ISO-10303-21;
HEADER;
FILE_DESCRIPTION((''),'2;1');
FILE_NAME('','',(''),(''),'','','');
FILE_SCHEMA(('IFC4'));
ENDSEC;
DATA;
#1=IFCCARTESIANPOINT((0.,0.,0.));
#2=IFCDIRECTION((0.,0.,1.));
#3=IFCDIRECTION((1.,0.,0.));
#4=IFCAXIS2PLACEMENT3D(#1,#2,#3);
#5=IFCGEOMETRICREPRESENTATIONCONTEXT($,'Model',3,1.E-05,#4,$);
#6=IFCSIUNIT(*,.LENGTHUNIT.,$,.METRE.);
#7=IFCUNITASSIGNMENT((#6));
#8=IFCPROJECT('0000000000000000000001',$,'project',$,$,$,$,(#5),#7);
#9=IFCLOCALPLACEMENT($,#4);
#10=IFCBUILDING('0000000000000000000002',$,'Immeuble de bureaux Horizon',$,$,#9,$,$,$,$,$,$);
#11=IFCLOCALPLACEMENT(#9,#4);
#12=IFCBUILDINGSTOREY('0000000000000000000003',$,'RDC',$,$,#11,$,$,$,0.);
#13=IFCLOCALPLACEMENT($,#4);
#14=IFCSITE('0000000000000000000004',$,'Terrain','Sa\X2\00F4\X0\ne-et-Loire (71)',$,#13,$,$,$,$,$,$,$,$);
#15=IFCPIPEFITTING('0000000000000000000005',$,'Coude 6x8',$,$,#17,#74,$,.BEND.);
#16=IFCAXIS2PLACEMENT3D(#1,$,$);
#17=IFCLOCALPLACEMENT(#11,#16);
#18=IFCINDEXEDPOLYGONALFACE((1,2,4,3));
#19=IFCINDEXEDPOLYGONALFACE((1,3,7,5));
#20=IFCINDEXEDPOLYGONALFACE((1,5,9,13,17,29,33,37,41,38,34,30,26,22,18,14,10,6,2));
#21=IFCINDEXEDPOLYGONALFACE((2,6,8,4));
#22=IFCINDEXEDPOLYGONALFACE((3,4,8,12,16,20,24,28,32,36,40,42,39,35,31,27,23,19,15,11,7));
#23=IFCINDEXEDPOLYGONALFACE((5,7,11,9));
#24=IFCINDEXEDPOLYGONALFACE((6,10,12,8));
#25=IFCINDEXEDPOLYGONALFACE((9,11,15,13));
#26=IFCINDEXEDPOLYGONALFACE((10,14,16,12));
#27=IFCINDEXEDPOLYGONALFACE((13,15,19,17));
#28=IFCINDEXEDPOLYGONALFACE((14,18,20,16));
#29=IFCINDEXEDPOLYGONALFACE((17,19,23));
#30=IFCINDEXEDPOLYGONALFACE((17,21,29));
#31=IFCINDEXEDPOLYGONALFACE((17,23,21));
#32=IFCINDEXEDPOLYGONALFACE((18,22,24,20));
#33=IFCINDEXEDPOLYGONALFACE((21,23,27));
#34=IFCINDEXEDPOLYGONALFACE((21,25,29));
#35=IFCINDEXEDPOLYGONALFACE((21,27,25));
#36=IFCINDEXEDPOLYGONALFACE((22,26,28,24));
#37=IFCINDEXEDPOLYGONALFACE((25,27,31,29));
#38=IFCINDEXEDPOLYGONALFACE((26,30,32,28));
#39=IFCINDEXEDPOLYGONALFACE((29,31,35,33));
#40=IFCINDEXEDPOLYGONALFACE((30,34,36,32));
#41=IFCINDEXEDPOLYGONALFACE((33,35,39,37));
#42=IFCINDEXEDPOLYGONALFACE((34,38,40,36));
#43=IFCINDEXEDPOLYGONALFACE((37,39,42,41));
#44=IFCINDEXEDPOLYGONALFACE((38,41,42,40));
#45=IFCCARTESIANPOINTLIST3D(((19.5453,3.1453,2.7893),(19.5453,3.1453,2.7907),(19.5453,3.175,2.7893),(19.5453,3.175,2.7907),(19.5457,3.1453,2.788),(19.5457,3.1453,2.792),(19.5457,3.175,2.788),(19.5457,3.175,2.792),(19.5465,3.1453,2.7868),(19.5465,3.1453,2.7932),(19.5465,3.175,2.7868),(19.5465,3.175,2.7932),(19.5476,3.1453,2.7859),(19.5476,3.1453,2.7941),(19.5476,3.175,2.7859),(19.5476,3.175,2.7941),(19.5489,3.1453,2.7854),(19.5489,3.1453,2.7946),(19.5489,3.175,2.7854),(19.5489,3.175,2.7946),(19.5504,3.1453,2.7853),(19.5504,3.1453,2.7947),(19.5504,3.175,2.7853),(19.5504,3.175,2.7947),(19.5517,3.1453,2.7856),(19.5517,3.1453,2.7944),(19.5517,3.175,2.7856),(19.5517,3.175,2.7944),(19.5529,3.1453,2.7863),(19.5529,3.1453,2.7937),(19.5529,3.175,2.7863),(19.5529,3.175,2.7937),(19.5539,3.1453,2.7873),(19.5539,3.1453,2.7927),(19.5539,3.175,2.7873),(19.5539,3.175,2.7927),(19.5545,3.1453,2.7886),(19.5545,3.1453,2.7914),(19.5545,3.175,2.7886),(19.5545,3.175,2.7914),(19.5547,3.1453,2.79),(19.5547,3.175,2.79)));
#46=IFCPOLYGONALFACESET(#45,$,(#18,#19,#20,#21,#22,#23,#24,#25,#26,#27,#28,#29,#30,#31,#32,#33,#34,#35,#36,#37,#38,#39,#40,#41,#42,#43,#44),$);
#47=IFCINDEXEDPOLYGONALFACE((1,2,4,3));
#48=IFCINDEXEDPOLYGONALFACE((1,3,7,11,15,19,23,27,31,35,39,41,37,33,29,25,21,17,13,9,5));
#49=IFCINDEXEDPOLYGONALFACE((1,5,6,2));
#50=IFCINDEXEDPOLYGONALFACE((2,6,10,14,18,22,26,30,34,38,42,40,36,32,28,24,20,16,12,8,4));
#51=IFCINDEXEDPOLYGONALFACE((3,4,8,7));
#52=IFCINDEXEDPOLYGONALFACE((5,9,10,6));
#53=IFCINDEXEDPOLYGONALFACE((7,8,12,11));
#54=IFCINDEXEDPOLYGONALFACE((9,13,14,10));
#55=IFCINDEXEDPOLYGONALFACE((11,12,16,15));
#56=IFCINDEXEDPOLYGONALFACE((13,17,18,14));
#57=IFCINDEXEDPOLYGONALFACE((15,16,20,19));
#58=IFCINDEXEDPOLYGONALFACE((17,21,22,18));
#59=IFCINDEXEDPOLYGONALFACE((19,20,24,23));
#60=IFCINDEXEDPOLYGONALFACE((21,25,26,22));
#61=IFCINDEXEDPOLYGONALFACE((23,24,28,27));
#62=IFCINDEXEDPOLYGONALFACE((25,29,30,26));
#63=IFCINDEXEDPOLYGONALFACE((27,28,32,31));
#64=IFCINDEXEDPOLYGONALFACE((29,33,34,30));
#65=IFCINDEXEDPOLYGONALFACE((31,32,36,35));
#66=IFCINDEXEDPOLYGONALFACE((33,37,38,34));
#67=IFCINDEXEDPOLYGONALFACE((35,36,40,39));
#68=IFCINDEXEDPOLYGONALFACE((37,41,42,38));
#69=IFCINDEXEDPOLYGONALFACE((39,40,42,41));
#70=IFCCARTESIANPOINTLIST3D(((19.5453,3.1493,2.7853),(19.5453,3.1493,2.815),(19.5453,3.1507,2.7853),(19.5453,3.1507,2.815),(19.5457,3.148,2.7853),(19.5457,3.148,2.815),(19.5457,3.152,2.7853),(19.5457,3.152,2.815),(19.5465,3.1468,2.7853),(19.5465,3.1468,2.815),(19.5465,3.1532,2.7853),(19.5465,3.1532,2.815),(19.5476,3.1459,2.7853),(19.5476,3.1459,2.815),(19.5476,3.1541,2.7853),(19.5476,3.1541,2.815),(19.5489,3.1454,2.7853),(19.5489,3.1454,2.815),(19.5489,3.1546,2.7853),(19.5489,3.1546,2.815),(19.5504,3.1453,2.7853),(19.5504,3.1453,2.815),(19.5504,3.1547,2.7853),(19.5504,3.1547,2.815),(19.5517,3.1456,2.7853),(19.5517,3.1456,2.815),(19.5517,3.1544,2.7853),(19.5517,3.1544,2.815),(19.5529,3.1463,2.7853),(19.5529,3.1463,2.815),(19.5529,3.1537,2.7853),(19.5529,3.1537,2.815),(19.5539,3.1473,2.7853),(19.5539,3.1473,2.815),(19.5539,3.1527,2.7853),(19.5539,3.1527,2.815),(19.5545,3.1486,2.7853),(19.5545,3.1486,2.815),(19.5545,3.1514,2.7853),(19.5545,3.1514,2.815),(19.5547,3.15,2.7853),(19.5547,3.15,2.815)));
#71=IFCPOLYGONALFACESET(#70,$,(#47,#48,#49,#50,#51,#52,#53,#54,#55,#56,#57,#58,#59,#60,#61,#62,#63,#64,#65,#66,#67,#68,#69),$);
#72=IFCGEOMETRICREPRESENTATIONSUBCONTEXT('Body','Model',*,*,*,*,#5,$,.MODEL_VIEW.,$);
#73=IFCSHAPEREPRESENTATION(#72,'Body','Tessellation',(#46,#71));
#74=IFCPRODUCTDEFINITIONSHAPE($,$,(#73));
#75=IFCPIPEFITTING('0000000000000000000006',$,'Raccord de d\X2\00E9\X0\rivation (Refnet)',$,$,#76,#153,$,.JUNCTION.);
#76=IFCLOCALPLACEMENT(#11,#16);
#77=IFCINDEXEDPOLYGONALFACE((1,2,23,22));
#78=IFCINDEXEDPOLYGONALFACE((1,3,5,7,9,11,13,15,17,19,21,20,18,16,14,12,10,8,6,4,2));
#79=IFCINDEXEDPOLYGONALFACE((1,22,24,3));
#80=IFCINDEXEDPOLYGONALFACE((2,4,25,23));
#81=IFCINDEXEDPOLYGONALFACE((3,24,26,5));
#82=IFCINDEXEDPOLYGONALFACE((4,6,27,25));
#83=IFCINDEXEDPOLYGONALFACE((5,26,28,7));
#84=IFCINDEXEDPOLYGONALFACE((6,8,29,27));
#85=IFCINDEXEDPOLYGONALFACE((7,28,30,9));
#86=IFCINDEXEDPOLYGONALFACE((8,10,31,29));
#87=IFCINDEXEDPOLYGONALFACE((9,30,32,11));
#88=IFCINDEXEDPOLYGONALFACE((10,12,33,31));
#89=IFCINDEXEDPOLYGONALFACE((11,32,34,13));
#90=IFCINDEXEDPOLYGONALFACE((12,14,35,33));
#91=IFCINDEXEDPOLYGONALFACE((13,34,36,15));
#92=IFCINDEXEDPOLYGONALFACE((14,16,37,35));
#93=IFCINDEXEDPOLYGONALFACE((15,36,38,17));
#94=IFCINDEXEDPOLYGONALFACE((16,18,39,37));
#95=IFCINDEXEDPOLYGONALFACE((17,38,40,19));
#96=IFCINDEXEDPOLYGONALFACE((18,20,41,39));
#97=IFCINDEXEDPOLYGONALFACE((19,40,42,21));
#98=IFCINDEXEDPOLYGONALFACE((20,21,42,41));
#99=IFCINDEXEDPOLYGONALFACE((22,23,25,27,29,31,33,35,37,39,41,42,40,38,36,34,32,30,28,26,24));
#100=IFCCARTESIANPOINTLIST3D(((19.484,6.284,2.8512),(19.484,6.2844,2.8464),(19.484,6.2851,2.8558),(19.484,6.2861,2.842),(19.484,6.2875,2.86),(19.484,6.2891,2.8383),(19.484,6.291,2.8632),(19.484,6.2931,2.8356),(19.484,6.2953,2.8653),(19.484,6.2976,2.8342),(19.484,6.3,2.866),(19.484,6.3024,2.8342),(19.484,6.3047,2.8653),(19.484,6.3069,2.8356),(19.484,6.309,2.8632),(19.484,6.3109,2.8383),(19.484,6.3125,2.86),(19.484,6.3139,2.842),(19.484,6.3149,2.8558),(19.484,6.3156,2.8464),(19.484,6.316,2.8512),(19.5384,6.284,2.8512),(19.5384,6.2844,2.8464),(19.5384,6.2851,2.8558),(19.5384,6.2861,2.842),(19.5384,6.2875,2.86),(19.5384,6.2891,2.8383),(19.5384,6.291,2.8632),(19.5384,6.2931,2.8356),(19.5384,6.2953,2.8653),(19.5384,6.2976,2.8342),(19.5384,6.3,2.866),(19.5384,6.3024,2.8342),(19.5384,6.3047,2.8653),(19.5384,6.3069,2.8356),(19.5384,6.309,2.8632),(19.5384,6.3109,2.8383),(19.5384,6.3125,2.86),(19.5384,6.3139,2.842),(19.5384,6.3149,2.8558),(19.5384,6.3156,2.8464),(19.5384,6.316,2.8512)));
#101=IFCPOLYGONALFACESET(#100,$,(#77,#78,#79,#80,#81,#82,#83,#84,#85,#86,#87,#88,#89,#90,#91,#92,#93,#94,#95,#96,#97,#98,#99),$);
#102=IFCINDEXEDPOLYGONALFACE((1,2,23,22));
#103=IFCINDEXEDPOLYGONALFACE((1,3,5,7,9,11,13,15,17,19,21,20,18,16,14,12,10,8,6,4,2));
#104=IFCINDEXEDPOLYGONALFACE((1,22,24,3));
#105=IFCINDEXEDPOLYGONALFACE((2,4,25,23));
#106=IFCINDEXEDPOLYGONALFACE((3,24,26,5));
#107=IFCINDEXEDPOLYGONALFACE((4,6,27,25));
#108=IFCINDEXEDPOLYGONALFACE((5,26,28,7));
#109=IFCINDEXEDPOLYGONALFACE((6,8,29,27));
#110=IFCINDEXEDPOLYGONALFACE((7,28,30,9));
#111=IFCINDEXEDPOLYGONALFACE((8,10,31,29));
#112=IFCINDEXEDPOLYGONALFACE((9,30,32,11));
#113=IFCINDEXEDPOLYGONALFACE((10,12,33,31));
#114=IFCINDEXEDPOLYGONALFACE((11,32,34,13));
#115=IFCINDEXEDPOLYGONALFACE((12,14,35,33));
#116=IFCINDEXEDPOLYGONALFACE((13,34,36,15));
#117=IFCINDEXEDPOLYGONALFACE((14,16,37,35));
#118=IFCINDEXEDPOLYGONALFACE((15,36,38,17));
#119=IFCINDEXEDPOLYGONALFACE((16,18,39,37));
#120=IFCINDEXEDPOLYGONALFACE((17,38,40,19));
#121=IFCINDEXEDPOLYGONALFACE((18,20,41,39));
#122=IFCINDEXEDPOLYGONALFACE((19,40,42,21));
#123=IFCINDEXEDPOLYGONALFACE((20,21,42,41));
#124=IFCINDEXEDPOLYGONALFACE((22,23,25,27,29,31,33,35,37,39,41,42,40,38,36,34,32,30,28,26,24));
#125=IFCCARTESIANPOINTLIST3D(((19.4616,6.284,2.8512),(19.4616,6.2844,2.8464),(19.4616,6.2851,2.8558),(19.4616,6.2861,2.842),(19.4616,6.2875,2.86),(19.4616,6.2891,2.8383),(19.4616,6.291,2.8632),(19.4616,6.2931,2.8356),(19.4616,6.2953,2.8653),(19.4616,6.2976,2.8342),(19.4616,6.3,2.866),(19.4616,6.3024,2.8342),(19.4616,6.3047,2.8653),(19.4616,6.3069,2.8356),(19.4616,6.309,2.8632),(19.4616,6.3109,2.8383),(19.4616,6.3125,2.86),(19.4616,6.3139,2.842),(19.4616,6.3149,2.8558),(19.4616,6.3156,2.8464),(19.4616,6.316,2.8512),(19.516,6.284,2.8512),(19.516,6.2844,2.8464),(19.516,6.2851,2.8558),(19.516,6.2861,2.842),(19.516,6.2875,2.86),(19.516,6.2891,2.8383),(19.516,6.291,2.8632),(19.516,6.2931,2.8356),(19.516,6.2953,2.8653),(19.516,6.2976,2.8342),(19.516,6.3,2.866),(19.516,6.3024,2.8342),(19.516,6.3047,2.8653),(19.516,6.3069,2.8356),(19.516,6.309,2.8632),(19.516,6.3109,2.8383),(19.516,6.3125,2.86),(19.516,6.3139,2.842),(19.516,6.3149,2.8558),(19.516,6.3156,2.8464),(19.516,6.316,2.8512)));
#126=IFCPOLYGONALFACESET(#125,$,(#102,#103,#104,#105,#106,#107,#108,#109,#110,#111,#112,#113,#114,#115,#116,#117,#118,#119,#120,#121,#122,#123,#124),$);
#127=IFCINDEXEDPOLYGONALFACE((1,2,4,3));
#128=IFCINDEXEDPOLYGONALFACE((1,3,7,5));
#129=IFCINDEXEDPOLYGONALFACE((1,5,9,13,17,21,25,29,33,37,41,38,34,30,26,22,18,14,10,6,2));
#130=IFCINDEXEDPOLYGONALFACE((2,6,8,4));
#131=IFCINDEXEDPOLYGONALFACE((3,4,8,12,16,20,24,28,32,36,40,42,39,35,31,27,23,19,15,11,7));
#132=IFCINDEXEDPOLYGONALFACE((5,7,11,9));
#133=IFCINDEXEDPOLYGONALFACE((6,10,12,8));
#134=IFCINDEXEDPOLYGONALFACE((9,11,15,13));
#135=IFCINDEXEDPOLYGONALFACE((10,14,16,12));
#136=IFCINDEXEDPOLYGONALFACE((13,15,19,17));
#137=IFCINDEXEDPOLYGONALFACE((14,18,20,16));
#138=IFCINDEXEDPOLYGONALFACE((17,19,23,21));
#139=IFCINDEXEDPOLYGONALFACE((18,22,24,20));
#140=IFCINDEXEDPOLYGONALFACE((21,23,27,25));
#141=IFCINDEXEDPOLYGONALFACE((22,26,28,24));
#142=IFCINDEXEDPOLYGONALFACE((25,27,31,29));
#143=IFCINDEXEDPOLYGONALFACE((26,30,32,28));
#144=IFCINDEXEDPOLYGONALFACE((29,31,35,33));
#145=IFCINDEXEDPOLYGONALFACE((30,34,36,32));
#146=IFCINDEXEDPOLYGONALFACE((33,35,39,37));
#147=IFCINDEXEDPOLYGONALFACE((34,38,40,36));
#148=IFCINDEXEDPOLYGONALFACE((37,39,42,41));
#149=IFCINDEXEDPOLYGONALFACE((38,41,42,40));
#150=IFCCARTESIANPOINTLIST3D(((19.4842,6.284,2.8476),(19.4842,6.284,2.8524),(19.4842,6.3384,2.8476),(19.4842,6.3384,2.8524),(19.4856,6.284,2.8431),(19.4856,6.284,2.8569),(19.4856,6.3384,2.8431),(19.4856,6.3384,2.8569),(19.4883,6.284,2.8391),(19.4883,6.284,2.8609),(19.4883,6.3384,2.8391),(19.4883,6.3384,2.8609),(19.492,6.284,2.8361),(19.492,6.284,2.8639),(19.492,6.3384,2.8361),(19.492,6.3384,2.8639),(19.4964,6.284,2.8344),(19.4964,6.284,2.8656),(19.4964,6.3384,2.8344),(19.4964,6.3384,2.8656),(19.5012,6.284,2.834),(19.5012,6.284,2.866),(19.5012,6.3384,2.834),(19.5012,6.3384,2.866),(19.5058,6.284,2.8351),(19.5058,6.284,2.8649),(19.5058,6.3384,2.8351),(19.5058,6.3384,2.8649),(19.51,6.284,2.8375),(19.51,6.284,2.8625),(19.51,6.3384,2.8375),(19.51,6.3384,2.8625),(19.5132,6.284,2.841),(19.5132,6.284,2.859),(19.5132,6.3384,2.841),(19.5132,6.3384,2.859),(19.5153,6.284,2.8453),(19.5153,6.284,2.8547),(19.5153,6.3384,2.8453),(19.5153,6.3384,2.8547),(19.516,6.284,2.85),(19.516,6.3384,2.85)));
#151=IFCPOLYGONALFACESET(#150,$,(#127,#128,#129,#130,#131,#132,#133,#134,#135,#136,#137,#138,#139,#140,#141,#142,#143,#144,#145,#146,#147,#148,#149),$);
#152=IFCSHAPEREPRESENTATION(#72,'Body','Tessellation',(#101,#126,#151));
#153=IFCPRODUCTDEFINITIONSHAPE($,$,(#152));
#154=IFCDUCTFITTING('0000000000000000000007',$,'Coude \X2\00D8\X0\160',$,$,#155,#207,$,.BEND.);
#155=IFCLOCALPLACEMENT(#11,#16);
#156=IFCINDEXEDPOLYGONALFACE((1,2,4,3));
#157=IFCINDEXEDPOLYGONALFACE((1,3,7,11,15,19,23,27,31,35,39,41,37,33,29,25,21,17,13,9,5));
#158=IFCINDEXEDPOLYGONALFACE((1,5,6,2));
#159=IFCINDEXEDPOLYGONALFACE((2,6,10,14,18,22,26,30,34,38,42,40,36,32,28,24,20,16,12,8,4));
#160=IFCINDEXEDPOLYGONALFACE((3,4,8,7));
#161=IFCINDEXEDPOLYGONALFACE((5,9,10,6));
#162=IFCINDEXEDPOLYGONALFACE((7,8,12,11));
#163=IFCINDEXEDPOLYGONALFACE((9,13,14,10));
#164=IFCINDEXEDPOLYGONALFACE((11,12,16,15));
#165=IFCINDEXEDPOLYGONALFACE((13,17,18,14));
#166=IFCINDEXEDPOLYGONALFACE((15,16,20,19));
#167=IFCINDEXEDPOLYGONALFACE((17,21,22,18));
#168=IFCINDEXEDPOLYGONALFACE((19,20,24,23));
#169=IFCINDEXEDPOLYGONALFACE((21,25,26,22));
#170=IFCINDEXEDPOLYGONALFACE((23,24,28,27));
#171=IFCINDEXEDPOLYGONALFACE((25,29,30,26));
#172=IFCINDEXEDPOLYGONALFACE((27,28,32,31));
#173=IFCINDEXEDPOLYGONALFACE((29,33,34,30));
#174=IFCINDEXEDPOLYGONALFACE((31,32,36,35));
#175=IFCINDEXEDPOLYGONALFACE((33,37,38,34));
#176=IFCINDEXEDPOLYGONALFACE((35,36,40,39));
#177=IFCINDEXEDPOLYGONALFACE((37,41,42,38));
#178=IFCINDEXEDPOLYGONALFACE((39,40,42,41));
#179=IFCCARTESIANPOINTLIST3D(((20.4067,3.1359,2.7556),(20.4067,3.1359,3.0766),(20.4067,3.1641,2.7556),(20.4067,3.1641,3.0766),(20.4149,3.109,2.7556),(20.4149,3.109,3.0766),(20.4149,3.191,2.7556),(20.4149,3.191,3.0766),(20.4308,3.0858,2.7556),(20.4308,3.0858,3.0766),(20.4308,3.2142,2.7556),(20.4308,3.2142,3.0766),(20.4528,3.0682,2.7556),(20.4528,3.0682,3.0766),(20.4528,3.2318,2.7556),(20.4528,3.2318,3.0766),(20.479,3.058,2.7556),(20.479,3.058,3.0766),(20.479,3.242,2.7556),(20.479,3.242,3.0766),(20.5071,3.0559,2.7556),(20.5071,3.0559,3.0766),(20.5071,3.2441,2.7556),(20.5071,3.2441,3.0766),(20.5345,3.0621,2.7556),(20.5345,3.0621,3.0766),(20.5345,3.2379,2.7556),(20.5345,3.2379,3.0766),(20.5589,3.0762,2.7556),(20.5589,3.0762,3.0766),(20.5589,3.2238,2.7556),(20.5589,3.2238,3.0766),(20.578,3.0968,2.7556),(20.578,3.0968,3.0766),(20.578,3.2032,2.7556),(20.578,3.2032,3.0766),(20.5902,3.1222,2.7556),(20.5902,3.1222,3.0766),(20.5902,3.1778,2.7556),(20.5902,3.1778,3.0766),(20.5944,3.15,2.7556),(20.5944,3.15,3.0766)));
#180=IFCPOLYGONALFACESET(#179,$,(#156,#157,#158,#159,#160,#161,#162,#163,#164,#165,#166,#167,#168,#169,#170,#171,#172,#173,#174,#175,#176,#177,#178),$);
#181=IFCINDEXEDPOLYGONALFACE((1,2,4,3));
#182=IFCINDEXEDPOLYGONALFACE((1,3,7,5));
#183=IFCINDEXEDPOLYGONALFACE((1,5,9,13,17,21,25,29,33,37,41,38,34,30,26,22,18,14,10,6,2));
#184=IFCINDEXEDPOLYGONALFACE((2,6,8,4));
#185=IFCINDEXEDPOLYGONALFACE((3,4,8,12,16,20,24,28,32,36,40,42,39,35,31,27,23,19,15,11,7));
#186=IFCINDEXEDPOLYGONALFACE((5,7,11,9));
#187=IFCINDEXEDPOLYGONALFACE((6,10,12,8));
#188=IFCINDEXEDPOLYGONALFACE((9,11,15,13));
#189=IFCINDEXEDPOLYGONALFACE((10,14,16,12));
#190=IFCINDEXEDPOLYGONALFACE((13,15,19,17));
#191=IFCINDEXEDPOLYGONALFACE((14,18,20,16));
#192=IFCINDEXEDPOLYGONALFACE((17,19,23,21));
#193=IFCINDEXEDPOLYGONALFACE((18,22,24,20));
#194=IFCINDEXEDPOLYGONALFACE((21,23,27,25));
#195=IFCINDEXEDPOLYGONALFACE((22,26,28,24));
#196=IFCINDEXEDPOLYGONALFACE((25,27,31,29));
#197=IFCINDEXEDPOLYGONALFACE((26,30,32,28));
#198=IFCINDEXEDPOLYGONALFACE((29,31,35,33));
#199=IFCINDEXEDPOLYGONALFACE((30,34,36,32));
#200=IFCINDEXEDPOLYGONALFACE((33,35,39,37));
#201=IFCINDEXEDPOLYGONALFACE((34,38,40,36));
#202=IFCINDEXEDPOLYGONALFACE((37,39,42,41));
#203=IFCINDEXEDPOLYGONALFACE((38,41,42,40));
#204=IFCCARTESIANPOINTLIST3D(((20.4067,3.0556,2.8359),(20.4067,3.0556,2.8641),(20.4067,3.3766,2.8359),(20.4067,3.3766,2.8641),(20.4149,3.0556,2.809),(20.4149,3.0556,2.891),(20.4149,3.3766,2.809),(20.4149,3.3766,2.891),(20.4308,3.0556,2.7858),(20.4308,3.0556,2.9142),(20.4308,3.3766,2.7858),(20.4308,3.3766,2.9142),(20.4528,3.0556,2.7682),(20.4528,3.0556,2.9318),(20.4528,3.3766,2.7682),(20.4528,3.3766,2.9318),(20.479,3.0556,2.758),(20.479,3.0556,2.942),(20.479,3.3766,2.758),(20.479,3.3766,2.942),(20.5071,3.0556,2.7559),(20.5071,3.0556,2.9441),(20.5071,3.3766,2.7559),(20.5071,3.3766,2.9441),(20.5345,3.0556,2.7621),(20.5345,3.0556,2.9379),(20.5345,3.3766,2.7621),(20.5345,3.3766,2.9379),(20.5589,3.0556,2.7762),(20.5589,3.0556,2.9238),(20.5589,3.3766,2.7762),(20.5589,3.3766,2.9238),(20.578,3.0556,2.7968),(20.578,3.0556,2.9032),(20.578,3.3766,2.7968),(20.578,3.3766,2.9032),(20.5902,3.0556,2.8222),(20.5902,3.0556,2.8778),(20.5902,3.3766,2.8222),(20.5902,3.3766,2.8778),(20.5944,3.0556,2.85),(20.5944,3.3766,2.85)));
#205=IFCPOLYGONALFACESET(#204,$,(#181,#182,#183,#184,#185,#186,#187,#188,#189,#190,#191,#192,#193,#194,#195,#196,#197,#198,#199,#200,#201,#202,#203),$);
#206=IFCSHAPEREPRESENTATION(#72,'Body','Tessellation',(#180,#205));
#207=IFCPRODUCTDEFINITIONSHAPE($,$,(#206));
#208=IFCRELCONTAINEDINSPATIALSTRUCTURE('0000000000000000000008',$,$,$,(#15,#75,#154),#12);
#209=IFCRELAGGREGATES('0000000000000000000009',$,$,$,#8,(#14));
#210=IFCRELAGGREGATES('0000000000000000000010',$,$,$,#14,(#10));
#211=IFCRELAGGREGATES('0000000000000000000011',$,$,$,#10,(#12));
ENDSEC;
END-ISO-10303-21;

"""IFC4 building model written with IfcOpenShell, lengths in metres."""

from ifc_helpers import new_model, si_unit, frame, origin_with_axes, place, context, subcontext, project, spatial, circle, extrude, element, save


model = new_model("IFC4")

# Units and contexts
model_context = context("Model", 3, precision=1e-05, world=origin_with_axes())
body_context = subcontext(model_context, "Body", "Model", "MODEL_VIEW")
ifc_project = project(units=[si_unit("LENGTHUNIT", "METRE")], contexts=[model_context])

# Site, building, storey
site_placement = place(None, origin_with_axes())
site = spatial("IfcSite", under=ifc_project, at=site_placement, Name="Terrain", Description="Saône-et-Loire (71)")
building_placement = place(None, origin_with_axes())
building = spatial("IfcBuilding", under=site, at=building_placement, Name="Immeuble de bureaux Horizon")
storey_placement = place(building_placement, origin_with_axes())
storey = spatial("IfcBuildingStorey", under=building, at=storey_placement, Name="RDC", Elevation=0.0)

# Pipe fittings
pipe_fitting_1_placement = place(storey_placement, frame((19.55, 3.15, 2.79), z_axis=(0.0, 0.0, 1.0), x_axis=(1.0, 0.0, 0.0)))
element("IfcPipeFitting", 1, at=pipe_fitting_1_placement, inside=storey, Name="Coude 6x8", PredefinedType="BEND", context=body_context, shape_type="SweptSolid", body=[
    extrude(circle(Radius=0.0047), frame((0.0, -0.0047, 0.0), z_axis=(0.0, 1.0, 0.0), x_axis=(1.0, 0.0, 0.0)), (0.0, 0.0, 1.0), 0.0297),
    extrude(circle(Radius=0.0047), frame((0.0, 0.0, -0.0047), z_axis=(0.0, 0.0, 1.0), x_axis=(1.0, 0.0, 0.0)), (0.0, 0.0, 1.0), 0.0297),
])
pipe_fitting_2_placement = place(storey_placement, frame((19.5, 6.3, 2.85), z_axis=(0.0, 0.0, 1.0), x_axis=(1.0, 0.0, 0.0)))
element("IfcPipeFitting", 2, at=pipe_fitting_2_placement, inside=storey, Name="Raccord de dérivation (Refnet)", PredefinedType="JUNCTION", context=body_context, shape_type="SweptSolid", body=[
    extrude(circle(Radius=0.016), frame((-0.016, 0.0, 0.0), z_axis=(1.0, 0.0, 0.0), x_axis=(0.0, 0.0, 1.0)), (0.0, 0.0, 1.0), 0.0544),
    extrude(circle(Radius=0.016), frame((0.016, 0.0, 0.0), z_axis=(-1.0, 0.0, 0.0), x_axis=(0.0, 0.0, 1.0)), (0.0, 0.0, 1.0), 0.0544),
    extrude(circle(Radius=0.016), frame((0.0, -0.016, 0.0), z_axis=(0.0, 1.0, 0.0), x_axis=(1.0, 0.0, 0.0)), (0.0, 0.0, 1.0), 0.0544),
])

# Duct fitting
duct_fitting_1_placement = place(storey_placement, frame((20.5, 3.15, 2.85), z_axis=(0.0, 0.0, 1.0), x_axis=(1.0, 0.0, 0.0)))
element("IfcDuctFitting", 3, at=duct_fitting_1_placement, inside=storey, Name="Coude Ø160", PredefinedType="BEND", context=body_context, shape_type="SweptSolid", body=[
    extrude(circle(Radius=0.0944), frame((0.0, 0.0, -0.0944), z_axis=(0.0, 0.0, 1.0), x_axis=(1.0, 0.0, 0.0)), (0.0, 0.0, 1.0), 0.321),
    extrude(circle(Radius=0.0944), frame((0.0, -0.0944, 0.0), z_axis=(0.0, 1.0, 0.0), x_axis=(1.0, 0.0, 0.0)), (0.0, 0.0, 1.0), 0.321),
])

save(model, "model.ifc")
